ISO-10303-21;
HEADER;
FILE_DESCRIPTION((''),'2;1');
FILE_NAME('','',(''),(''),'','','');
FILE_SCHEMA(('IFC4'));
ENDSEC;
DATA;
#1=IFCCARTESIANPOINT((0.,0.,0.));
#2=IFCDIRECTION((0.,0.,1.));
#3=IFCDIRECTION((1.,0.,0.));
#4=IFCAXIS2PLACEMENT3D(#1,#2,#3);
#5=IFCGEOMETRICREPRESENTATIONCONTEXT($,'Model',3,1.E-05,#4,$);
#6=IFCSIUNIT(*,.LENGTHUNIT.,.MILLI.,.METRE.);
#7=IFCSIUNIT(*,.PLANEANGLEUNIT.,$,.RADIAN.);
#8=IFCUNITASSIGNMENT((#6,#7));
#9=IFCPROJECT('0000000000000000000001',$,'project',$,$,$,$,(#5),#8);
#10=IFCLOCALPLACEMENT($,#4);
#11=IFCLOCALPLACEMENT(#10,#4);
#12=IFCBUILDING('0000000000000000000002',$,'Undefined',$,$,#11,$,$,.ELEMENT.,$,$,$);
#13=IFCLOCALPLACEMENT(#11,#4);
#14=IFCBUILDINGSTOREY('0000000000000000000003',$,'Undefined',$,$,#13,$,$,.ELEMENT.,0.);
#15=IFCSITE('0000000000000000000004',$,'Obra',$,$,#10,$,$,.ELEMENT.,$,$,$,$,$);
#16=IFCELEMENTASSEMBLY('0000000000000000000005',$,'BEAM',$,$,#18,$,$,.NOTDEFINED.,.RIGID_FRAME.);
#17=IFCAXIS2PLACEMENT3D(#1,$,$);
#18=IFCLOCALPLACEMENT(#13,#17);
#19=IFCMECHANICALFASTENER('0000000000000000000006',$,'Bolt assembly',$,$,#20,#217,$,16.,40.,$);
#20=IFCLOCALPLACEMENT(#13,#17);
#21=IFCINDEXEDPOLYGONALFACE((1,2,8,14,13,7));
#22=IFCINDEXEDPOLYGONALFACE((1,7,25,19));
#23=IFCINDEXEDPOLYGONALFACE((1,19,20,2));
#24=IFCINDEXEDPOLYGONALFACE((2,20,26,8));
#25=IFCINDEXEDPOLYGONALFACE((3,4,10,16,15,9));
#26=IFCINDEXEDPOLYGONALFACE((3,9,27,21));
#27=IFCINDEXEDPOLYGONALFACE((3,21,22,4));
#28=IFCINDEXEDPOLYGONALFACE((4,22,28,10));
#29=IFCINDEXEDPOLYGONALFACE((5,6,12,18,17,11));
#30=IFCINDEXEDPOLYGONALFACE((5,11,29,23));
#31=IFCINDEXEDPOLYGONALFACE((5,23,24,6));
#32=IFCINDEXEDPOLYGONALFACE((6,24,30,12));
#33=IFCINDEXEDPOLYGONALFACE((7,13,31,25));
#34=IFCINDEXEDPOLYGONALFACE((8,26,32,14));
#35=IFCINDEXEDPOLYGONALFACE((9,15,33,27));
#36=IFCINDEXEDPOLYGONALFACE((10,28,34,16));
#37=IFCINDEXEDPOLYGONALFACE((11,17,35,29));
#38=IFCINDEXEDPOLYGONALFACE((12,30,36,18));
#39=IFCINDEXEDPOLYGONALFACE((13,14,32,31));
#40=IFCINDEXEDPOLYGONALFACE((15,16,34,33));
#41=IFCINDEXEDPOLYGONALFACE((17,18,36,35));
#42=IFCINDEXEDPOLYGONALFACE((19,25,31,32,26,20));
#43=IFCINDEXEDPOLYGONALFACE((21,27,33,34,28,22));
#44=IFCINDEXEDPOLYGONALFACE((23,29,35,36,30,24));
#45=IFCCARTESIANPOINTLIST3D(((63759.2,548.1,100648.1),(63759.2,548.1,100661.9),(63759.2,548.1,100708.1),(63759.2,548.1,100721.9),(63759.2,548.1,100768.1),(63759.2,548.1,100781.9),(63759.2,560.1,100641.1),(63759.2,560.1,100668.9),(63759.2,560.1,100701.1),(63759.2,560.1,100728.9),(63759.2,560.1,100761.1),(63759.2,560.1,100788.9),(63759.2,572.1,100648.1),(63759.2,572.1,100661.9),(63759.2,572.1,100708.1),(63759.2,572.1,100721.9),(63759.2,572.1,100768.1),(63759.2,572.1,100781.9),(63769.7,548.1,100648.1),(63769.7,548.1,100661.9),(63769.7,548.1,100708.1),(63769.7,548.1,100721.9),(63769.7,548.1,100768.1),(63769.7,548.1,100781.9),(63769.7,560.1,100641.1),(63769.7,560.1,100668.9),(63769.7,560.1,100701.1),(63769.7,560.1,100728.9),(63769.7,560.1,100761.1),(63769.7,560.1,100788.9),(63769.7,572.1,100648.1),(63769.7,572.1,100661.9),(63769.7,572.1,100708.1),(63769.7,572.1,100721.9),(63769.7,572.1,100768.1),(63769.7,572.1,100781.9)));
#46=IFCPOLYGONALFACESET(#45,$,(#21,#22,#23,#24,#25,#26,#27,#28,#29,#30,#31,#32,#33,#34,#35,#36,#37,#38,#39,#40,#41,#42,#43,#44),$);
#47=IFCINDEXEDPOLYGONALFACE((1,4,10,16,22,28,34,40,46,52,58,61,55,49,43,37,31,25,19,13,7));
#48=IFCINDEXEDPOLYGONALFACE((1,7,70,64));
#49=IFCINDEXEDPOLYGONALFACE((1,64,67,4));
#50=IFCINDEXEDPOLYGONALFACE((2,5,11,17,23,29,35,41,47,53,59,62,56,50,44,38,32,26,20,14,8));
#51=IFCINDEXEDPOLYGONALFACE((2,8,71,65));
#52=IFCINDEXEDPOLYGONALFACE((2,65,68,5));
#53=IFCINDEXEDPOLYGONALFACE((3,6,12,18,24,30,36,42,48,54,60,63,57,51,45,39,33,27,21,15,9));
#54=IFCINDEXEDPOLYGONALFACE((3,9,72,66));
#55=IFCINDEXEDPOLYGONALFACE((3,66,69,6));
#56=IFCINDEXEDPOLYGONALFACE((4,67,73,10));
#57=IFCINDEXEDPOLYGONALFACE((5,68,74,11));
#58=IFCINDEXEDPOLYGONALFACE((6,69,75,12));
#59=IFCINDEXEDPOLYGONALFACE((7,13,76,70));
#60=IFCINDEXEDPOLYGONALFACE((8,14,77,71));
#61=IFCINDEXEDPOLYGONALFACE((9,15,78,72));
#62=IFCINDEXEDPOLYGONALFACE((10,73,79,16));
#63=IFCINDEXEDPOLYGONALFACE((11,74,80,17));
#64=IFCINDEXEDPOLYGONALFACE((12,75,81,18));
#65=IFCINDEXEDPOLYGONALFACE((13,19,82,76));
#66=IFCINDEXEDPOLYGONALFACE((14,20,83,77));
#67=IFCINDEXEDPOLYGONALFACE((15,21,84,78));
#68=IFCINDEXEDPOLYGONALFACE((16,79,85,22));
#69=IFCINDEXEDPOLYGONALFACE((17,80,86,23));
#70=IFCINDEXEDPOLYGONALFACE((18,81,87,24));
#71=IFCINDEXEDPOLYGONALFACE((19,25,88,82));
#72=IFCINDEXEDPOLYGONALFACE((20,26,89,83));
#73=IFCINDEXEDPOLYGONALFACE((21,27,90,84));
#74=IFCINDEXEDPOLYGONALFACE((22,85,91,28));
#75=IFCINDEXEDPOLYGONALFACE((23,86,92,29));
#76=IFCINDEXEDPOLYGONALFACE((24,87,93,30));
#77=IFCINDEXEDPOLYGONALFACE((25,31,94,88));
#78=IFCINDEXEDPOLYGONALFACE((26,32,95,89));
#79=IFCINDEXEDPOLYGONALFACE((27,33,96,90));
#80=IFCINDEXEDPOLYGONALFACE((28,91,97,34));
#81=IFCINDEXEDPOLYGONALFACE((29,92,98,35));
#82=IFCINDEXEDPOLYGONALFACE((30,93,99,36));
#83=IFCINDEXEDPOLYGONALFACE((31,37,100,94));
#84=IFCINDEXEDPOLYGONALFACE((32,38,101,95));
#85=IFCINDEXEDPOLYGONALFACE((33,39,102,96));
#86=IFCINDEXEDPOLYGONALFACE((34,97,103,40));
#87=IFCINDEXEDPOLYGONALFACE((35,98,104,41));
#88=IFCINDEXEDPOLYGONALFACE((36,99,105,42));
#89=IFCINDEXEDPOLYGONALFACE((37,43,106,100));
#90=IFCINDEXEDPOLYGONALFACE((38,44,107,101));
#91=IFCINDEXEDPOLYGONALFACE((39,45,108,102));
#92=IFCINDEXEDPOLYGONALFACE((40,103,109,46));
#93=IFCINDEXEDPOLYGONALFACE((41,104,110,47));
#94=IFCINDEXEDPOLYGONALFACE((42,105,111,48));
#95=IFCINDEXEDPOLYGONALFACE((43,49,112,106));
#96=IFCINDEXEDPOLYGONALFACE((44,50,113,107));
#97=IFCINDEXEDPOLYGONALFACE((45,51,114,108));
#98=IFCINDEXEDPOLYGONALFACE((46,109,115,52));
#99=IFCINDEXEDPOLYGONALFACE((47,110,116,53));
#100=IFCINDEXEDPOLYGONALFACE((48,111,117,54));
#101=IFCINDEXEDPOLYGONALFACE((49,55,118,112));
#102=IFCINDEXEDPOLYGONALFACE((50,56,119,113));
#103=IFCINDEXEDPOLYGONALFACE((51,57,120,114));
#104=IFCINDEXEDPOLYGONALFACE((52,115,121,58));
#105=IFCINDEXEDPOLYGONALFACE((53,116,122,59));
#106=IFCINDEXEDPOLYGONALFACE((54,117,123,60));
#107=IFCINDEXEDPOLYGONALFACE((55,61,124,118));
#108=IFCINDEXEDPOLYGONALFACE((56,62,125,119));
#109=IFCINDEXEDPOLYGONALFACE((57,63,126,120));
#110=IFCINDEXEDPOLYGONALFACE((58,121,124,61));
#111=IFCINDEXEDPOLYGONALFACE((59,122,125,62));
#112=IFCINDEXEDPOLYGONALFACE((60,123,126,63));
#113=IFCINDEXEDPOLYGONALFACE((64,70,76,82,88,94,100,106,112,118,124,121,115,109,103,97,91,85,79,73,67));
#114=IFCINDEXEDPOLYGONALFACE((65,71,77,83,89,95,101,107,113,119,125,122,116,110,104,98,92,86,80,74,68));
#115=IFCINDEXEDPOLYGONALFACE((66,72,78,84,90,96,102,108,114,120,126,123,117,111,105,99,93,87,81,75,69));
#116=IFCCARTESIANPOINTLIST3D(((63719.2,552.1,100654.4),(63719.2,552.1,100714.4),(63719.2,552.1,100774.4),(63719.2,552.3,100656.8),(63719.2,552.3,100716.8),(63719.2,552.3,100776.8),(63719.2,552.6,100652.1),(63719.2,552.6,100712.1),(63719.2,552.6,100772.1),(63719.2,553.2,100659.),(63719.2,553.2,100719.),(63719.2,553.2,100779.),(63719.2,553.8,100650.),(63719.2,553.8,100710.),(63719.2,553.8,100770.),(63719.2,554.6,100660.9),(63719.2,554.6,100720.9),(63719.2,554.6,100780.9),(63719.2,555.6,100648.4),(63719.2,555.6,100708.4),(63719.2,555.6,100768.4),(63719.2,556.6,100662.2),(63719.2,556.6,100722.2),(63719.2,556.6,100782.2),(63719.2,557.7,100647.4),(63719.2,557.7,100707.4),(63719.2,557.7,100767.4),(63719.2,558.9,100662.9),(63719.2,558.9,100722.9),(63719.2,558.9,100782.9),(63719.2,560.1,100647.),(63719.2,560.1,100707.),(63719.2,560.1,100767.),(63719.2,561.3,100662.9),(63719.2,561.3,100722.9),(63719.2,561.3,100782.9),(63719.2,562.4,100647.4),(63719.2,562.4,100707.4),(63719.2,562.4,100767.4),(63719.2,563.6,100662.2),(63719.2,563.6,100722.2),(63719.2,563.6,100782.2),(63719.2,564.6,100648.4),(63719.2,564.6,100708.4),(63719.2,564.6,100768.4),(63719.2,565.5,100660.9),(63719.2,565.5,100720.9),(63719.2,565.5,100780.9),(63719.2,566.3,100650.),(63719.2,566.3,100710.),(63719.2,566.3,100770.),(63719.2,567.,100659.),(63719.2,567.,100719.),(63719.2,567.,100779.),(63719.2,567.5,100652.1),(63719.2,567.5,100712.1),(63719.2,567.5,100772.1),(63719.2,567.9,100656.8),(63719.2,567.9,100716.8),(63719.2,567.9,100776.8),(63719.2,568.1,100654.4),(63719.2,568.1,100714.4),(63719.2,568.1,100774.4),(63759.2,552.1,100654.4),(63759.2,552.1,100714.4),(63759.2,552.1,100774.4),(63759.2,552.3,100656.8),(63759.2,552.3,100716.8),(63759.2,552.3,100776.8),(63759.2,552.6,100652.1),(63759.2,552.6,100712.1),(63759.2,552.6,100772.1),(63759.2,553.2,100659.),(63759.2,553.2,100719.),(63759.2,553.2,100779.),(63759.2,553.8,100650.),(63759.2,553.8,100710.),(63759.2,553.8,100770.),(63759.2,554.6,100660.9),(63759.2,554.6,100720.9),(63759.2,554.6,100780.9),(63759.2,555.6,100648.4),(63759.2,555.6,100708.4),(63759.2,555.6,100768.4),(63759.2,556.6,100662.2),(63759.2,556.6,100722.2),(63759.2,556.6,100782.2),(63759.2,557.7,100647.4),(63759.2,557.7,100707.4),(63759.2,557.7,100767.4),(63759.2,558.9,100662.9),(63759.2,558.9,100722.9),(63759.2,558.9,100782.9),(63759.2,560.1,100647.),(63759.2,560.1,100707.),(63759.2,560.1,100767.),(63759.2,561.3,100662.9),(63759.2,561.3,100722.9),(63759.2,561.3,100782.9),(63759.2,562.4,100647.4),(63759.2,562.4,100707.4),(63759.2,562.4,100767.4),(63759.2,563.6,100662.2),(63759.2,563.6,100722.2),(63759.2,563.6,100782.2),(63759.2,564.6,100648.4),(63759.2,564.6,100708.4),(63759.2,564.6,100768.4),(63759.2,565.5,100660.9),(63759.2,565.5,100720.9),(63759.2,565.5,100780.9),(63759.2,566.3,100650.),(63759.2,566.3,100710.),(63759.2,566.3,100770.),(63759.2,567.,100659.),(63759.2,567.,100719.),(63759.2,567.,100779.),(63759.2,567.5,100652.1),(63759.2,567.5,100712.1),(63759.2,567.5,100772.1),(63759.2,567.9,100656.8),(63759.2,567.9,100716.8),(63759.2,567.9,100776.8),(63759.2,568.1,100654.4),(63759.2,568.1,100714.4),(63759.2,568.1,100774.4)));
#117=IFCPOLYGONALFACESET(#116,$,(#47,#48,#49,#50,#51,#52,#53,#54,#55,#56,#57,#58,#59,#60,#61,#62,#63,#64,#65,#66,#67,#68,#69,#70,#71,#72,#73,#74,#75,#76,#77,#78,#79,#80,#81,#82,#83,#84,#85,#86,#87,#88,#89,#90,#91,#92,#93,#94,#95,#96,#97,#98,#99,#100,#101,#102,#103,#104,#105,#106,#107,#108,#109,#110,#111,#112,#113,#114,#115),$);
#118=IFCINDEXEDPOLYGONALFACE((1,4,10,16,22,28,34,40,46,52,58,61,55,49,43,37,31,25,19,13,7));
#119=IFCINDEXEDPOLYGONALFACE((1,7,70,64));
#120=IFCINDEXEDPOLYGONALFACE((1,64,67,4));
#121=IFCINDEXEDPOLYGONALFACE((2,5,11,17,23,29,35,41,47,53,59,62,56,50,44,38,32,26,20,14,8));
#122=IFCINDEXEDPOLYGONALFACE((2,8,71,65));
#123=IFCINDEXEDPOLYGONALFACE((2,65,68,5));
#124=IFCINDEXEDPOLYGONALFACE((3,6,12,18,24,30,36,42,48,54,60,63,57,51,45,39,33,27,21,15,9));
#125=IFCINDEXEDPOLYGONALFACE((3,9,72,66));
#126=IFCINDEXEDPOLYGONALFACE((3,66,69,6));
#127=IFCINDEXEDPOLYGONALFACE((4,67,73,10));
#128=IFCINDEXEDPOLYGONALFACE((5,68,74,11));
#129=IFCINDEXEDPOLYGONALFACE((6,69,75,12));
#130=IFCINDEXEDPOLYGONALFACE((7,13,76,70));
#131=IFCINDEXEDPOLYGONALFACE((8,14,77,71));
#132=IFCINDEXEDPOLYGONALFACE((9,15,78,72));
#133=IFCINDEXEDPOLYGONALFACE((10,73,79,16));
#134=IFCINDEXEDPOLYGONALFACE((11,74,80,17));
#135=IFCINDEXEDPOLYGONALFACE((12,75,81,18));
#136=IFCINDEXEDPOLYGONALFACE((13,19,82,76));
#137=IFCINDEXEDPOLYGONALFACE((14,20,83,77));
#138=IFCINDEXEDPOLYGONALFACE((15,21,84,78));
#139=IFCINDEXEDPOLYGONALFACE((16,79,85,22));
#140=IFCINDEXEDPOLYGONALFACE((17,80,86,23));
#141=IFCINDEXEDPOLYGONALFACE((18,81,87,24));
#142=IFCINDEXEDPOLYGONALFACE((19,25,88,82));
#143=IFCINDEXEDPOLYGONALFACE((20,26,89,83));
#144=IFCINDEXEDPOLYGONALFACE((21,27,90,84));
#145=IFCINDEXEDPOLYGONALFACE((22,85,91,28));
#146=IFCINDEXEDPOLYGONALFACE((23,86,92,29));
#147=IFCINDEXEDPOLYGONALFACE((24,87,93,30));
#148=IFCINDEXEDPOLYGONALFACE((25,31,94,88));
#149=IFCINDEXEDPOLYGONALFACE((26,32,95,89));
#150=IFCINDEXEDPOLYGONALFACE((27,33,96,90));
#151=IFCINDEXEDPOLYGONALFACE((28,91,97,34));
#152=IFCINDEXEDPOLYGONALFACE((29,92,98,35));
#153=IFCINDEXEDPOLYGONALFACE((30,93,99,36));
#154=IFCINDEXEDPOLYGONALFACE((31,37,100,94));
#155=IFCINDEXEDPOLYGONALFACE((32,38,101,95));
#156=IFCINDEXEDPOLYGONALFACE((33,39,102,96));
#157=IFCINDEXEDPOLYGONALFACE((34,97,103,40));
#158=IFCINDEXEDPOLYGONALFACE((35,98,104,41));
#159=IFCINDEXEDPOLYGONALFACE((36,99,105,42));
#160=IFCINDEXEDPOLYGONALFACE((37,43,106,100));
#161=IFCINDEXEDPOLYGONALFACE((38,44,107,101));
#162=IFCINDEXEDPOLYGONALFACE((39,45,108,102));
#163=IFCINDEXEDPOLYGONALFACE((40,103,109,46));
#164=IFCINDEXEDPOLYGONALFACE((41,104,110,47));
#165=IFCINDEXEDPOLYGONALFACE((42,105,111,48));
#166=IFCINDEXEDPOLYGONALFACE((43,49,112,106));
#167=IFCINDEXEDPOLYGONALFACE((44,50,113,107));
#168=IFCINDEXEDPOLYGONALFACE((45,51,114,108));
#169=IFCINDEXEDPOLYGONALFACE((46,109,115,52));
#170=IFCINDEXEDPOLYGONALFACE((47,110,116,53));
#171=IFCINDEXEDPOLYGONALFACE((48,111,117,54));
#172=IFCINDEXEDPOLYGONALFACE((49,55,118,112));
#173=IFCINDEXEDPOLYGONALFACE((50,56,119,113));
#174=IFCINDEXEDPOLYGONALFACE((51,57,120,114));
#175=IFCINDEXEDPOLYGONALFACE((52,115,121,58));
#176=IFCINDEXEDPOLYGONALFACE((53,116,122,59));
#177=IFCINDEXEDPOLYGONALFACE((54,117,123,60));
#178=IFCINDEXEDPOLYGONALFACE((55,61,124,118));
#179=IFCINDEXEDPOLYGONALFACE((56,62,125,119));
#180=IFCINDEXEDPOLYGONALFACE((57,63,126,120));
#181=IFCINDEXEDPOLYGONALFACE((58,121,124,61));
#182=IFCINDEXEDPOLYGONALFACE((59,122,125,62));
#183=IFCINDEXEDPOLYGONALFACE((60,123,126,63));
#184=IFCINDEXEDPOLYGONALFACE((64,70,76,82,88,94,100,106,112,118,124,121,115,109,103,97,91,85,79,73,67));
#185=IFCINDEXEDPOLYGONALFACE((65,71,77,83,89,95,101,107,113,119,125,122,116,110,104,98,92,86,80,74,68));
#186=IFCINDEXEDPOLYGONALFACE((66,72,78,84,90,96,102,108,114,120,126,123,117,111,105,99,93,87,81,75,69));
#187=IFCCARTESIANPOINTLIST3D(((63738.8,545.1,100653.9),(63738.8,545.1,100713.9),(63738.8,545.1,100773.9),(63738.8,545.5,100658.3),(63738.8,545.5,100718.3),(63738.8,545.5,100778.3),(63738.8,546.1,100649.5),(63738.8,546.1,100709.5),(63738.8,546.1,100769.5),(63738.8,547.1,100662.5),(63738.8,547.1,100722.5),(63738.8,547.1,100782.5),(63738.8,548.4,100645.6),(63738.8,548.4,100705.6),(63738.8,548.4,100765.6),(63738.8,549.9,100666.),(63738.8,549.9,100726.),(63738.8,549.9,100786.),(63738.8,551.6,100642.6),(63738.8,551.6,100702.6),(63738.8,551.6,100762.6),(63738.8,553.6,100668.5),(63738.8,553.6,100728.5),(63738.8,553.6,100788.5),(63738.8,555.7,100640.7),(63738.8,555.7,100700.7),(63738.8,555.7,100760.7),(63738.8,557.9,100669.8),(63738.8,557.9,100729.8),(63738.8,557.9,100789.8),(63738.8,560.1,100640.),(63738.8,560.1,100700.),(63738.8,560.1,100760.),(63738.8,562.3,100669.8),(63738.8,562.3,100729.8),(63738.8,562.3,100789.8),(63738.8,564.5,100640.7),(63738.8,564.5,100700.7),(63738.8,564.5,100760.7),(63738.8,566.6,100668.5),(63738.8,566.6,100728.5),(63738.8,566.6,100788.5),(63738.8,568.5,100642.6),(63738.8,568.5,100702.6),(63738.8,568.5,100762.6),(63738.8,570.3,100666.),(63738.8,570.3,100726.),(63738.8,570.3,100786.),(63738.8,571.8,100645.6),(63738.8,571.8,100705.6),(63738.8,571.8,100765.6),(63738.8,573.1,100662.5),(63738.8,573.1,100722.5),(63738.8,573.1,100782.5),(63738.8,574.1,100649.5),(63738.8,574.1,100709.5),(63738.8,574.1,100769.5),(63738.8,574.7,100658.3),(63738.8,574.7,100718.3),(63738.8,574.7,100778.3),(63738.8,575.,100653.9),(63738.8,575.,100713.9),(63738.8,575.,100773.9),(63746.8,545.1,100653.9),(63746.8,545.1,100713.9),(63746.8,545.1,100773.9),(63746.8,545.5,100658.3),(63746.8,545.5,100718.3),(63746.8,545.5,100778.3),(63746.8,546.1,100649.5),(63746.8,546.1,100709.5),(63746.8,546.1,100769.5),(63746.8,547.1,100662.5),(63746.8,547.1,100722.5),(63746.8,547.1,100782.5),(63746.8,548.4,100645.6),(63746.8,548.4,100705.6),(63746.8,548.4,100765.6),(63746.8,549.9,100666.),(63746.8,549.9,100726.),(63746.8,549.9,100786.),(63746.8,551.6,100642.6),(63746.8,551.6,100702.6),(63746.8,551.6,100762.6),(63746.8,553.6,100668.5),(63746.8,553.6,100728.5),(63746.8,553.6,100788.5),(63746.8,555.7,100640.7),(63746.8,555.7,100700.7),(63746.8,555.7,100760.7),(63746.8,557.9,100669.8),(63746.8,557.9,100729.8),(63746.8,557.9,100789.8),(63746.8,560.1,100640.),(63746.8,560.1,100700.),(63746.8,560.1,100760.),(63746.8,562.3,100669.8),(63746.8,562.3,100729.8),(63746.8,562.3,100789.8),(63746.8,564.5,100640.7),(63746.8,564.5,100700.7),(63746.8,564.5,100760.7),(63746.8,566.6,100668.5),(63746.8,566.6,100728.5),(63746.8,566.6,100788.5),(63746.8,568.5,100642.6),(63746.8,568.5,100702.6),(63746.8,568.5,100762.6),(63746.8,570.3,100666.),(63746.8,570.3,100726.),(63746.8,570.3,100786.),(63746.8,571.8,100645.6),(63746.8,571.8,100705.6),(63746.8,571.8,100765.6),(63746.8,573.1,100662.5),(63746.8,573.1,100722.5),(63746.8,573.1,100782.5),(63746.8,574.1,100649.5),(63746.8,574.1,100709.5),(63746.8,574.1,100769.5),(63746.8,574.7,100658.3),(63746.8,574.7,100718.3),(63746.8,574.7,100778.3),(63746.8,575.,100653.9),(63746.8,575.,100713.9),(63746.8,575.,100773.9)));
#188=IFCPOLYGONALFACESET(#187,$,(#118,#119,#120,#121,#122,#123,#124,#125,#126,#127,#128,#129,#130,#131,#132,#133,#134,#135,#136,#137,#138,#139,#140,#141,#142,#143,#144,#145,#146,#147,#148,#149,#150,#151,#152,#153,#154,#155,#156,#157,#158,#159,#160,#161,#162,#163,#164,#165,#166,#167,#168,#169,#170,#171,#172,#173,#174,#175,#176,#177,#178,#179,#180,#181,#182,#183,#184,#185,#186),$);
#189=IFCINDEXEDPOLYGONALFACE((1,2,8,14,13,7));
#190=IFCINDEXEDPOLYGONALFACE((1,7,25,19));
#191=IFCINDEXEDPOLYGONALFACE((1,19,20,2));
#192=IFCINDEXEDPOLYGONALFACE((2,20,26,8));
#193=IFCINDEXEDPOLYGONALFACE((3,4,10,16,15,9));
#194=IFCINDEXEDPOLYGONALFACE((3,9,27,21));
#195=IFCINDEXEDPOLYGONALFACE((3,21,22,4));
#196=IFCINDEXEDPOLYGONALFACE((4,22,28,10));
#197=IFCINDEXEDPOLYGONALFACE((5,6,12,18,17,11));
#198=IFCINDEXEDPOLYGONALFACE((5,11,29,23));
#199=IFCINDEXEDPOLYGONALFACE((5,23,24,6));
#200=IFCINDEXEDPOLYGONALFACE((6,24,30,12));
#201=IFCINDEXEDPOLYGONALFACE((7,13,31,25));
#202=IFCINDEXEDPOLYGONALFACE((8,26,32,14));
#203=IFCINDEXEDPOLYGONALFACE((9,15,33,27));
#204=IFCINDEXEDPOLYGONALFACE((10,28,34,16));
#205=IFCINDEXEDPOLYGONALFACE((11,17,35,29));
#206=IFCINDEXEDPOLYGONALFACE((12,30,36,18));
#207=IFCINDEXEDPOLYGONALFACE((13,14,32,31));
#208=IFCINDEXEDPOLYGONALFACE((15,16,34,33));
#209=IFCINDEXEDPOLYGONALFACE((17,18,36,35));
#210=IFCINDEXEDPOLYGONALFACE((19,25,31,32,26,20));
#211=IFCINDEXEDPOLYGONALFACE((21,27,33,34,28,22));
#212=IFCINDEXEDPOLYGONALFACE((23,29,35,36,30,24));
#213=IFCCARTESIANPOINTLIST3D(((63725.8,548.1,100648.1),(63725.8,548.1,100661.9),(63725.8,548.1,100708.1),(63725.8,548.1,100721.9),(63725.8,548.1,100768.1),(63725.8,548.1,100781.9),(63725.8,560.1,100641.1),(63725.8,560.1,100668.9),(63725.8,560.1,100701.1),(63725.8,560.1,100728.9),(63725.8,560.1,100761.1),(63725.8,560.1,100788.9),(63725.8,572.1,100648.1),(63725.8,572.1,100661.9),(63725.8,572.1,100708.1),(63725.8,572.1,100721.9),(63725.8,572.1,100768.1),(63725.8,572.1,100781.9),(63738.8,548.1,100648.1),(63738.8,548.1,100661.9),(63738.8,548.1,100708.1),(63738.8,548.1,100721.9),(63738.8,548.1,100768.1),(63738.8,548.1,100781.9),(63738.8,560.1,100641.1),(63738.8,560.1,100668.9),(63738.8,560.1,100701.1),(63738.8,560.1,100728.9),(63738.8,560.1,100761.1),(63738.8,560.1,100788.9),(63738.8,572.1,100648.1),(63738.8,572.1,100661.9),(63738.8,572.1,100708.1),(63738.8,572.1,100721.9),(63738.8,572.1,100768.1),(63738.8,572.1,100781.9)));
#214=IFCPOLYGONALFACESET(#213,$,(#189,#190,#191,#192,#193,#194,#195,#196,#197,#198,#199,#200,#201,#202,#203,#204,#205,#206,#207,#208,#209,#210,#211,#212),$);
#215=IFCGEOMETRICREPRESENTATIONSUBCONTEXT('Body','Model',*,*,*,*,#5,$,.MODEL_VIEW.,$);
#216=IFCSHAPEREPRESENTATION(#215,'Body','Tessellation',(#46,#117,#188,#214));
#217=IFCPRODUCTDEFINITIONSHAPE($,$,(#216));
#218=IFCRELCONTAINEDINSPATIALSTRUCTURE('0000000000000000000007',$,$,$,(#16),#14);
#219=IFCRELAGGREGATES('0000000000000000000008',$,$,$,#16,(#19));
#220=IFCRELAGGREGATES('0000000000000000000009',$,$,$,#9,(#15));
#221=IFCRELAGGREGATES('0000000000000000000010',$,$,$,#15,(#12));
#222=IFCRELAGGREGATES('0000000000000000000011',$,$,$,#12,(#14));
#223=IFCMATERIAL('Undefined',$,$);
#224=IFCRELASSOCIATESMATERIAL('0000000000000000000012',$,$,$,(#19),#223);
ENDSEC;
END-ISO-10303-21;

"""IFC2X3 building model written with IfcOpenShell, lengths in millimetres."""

from ifc_helpers import new_model, si_unit, frame, origin_with_axes, origin_2d_with_axis, place, context, subcontext, project, spatial, polyline, circle, outline, extrude, source, transform, mapped, material, element, aggregate, save


model = new_model("IFC2X3")

# Units and contexts
model_context = context("Model", 3, precision=1e-05, world=origin_with_axes())
body_context = subcontext(model_context, "Body", "Model", "MODEL_VIEW")
ifc_project = project(units=[si_unit("LENGTHUNIT", "METRE", prefix="MILLI"), si_unit("PLANEANGLEUNIT", "RADIAN")], contexts=[model_context])

# Site, building, storey
site_placement = place(None, origin_with_axes())
site = spatial("IfcSite", under=ifc_project, at=site_placement, Name="Obra", CompositionType="ELEMENT")
building_placement = place(site_placement, origin_with_axes())
building = spatial("IfcBuilding", under=site, at=building_placement, Name="Undefined", CompositionType="ELEMENT")
storey_placement = place(building_placement, origin_with_axes())
storey = spatial("IfcBuildingStorey", under=building, at=storey_placement, Name="Undefined", CompositionType="ELEMENT", Elevation=0.0)

# Shared definitions
ifc_material_1 = material(Name="Undefined")

# Element assembly, mechanical fastener
shared_shape_1 = source(origin_with_axes(), body_context, "Body", "SweptSolid", [
    extrude(outline(polyline([(13.9, 0.0), (6.9, 12.0), (-6.9, 12.0), (-13.9, 0.0), (-6.9, -12.0), (6.9, -12.0), (13.9, 0.0)])), frame((0.0, -19.7, 0.0), z_axis=(0.0, 1.0, 0.0), x_axis=(1.0, 0.0, 0.0)), (0.0, 0.0, 1.0), 10.6),
    extrude(circle(Radius=8.0, at=origin_2d_with_axis()), frame((0.0, -9.1, 0.0), z_axis=(0.0, 1.0, 0.0), x_axis=(1.0, 0.0, 0.0)), (0.0, 0.0, 1.0), 40.0),
    extrude(circle(Radius=15.0, at=origin_2d_with_axis()), frame((0.0, 3.3, 0.0), z_axis=(0.0, 1.0, 0.0), x_axis=(1.0, 0.0, 0.0)), (0.0, 0.0, 1.0), 8.0),
    extrude(outline(polyline([(13.9, 0.0), (6.9, 12.0), (-6.9, 12.0), (-13.9, 0.0), (-6.9, -12.0), (6.9, -12.0), (13.9, 0.0)])), frame((0.0, 11.3, 0.0), z_axis=(0.0, 1.0, 0.0), x_axis=(1.0, 0.0, 0.0)), (0.0, 0.0, 1.0), 13.0),
])
assembly_1_placement = place(storey_placement, origin_with_axes())
assembly_1 = element("IfcElementAssembly", 1, at=assembly_1_placement, inside=storey, Name="BEAM", AssemblyPlace="NOTDEFINED", PredefinedType="RIGID_FRAME")
mechanical_fastener_1_placement = place(assembly_1_placement, frame((63750.1, 510.1, 100835.0), z_axis=(-0.000002, 1.0, 0.0), x_axis=(0.0, 0.0, -1.0)))
mechanical_fastener_1 = element("IfcMechanicalFastener", 2, at=mechanical_fastener_1_placement, material=ifc_material_1, Name="Bolt assembly", NominalDiameter=16.0, NominalLength=40.0, context=body_context, shape_type="MappedRepresentation", body=[
    mapped(shared_shape_1, transform((60.0, 0.0, 50.0))),
    mapped(shared_shape_1, transform((120.0, 0.0, 50.0))),
    mapped(shared_shape_1, transform((180.0, 0.0, 50.0))),
])

aggregate(assembly_1, [mechanical_fastener_1])

save(model, "model.ifc")
